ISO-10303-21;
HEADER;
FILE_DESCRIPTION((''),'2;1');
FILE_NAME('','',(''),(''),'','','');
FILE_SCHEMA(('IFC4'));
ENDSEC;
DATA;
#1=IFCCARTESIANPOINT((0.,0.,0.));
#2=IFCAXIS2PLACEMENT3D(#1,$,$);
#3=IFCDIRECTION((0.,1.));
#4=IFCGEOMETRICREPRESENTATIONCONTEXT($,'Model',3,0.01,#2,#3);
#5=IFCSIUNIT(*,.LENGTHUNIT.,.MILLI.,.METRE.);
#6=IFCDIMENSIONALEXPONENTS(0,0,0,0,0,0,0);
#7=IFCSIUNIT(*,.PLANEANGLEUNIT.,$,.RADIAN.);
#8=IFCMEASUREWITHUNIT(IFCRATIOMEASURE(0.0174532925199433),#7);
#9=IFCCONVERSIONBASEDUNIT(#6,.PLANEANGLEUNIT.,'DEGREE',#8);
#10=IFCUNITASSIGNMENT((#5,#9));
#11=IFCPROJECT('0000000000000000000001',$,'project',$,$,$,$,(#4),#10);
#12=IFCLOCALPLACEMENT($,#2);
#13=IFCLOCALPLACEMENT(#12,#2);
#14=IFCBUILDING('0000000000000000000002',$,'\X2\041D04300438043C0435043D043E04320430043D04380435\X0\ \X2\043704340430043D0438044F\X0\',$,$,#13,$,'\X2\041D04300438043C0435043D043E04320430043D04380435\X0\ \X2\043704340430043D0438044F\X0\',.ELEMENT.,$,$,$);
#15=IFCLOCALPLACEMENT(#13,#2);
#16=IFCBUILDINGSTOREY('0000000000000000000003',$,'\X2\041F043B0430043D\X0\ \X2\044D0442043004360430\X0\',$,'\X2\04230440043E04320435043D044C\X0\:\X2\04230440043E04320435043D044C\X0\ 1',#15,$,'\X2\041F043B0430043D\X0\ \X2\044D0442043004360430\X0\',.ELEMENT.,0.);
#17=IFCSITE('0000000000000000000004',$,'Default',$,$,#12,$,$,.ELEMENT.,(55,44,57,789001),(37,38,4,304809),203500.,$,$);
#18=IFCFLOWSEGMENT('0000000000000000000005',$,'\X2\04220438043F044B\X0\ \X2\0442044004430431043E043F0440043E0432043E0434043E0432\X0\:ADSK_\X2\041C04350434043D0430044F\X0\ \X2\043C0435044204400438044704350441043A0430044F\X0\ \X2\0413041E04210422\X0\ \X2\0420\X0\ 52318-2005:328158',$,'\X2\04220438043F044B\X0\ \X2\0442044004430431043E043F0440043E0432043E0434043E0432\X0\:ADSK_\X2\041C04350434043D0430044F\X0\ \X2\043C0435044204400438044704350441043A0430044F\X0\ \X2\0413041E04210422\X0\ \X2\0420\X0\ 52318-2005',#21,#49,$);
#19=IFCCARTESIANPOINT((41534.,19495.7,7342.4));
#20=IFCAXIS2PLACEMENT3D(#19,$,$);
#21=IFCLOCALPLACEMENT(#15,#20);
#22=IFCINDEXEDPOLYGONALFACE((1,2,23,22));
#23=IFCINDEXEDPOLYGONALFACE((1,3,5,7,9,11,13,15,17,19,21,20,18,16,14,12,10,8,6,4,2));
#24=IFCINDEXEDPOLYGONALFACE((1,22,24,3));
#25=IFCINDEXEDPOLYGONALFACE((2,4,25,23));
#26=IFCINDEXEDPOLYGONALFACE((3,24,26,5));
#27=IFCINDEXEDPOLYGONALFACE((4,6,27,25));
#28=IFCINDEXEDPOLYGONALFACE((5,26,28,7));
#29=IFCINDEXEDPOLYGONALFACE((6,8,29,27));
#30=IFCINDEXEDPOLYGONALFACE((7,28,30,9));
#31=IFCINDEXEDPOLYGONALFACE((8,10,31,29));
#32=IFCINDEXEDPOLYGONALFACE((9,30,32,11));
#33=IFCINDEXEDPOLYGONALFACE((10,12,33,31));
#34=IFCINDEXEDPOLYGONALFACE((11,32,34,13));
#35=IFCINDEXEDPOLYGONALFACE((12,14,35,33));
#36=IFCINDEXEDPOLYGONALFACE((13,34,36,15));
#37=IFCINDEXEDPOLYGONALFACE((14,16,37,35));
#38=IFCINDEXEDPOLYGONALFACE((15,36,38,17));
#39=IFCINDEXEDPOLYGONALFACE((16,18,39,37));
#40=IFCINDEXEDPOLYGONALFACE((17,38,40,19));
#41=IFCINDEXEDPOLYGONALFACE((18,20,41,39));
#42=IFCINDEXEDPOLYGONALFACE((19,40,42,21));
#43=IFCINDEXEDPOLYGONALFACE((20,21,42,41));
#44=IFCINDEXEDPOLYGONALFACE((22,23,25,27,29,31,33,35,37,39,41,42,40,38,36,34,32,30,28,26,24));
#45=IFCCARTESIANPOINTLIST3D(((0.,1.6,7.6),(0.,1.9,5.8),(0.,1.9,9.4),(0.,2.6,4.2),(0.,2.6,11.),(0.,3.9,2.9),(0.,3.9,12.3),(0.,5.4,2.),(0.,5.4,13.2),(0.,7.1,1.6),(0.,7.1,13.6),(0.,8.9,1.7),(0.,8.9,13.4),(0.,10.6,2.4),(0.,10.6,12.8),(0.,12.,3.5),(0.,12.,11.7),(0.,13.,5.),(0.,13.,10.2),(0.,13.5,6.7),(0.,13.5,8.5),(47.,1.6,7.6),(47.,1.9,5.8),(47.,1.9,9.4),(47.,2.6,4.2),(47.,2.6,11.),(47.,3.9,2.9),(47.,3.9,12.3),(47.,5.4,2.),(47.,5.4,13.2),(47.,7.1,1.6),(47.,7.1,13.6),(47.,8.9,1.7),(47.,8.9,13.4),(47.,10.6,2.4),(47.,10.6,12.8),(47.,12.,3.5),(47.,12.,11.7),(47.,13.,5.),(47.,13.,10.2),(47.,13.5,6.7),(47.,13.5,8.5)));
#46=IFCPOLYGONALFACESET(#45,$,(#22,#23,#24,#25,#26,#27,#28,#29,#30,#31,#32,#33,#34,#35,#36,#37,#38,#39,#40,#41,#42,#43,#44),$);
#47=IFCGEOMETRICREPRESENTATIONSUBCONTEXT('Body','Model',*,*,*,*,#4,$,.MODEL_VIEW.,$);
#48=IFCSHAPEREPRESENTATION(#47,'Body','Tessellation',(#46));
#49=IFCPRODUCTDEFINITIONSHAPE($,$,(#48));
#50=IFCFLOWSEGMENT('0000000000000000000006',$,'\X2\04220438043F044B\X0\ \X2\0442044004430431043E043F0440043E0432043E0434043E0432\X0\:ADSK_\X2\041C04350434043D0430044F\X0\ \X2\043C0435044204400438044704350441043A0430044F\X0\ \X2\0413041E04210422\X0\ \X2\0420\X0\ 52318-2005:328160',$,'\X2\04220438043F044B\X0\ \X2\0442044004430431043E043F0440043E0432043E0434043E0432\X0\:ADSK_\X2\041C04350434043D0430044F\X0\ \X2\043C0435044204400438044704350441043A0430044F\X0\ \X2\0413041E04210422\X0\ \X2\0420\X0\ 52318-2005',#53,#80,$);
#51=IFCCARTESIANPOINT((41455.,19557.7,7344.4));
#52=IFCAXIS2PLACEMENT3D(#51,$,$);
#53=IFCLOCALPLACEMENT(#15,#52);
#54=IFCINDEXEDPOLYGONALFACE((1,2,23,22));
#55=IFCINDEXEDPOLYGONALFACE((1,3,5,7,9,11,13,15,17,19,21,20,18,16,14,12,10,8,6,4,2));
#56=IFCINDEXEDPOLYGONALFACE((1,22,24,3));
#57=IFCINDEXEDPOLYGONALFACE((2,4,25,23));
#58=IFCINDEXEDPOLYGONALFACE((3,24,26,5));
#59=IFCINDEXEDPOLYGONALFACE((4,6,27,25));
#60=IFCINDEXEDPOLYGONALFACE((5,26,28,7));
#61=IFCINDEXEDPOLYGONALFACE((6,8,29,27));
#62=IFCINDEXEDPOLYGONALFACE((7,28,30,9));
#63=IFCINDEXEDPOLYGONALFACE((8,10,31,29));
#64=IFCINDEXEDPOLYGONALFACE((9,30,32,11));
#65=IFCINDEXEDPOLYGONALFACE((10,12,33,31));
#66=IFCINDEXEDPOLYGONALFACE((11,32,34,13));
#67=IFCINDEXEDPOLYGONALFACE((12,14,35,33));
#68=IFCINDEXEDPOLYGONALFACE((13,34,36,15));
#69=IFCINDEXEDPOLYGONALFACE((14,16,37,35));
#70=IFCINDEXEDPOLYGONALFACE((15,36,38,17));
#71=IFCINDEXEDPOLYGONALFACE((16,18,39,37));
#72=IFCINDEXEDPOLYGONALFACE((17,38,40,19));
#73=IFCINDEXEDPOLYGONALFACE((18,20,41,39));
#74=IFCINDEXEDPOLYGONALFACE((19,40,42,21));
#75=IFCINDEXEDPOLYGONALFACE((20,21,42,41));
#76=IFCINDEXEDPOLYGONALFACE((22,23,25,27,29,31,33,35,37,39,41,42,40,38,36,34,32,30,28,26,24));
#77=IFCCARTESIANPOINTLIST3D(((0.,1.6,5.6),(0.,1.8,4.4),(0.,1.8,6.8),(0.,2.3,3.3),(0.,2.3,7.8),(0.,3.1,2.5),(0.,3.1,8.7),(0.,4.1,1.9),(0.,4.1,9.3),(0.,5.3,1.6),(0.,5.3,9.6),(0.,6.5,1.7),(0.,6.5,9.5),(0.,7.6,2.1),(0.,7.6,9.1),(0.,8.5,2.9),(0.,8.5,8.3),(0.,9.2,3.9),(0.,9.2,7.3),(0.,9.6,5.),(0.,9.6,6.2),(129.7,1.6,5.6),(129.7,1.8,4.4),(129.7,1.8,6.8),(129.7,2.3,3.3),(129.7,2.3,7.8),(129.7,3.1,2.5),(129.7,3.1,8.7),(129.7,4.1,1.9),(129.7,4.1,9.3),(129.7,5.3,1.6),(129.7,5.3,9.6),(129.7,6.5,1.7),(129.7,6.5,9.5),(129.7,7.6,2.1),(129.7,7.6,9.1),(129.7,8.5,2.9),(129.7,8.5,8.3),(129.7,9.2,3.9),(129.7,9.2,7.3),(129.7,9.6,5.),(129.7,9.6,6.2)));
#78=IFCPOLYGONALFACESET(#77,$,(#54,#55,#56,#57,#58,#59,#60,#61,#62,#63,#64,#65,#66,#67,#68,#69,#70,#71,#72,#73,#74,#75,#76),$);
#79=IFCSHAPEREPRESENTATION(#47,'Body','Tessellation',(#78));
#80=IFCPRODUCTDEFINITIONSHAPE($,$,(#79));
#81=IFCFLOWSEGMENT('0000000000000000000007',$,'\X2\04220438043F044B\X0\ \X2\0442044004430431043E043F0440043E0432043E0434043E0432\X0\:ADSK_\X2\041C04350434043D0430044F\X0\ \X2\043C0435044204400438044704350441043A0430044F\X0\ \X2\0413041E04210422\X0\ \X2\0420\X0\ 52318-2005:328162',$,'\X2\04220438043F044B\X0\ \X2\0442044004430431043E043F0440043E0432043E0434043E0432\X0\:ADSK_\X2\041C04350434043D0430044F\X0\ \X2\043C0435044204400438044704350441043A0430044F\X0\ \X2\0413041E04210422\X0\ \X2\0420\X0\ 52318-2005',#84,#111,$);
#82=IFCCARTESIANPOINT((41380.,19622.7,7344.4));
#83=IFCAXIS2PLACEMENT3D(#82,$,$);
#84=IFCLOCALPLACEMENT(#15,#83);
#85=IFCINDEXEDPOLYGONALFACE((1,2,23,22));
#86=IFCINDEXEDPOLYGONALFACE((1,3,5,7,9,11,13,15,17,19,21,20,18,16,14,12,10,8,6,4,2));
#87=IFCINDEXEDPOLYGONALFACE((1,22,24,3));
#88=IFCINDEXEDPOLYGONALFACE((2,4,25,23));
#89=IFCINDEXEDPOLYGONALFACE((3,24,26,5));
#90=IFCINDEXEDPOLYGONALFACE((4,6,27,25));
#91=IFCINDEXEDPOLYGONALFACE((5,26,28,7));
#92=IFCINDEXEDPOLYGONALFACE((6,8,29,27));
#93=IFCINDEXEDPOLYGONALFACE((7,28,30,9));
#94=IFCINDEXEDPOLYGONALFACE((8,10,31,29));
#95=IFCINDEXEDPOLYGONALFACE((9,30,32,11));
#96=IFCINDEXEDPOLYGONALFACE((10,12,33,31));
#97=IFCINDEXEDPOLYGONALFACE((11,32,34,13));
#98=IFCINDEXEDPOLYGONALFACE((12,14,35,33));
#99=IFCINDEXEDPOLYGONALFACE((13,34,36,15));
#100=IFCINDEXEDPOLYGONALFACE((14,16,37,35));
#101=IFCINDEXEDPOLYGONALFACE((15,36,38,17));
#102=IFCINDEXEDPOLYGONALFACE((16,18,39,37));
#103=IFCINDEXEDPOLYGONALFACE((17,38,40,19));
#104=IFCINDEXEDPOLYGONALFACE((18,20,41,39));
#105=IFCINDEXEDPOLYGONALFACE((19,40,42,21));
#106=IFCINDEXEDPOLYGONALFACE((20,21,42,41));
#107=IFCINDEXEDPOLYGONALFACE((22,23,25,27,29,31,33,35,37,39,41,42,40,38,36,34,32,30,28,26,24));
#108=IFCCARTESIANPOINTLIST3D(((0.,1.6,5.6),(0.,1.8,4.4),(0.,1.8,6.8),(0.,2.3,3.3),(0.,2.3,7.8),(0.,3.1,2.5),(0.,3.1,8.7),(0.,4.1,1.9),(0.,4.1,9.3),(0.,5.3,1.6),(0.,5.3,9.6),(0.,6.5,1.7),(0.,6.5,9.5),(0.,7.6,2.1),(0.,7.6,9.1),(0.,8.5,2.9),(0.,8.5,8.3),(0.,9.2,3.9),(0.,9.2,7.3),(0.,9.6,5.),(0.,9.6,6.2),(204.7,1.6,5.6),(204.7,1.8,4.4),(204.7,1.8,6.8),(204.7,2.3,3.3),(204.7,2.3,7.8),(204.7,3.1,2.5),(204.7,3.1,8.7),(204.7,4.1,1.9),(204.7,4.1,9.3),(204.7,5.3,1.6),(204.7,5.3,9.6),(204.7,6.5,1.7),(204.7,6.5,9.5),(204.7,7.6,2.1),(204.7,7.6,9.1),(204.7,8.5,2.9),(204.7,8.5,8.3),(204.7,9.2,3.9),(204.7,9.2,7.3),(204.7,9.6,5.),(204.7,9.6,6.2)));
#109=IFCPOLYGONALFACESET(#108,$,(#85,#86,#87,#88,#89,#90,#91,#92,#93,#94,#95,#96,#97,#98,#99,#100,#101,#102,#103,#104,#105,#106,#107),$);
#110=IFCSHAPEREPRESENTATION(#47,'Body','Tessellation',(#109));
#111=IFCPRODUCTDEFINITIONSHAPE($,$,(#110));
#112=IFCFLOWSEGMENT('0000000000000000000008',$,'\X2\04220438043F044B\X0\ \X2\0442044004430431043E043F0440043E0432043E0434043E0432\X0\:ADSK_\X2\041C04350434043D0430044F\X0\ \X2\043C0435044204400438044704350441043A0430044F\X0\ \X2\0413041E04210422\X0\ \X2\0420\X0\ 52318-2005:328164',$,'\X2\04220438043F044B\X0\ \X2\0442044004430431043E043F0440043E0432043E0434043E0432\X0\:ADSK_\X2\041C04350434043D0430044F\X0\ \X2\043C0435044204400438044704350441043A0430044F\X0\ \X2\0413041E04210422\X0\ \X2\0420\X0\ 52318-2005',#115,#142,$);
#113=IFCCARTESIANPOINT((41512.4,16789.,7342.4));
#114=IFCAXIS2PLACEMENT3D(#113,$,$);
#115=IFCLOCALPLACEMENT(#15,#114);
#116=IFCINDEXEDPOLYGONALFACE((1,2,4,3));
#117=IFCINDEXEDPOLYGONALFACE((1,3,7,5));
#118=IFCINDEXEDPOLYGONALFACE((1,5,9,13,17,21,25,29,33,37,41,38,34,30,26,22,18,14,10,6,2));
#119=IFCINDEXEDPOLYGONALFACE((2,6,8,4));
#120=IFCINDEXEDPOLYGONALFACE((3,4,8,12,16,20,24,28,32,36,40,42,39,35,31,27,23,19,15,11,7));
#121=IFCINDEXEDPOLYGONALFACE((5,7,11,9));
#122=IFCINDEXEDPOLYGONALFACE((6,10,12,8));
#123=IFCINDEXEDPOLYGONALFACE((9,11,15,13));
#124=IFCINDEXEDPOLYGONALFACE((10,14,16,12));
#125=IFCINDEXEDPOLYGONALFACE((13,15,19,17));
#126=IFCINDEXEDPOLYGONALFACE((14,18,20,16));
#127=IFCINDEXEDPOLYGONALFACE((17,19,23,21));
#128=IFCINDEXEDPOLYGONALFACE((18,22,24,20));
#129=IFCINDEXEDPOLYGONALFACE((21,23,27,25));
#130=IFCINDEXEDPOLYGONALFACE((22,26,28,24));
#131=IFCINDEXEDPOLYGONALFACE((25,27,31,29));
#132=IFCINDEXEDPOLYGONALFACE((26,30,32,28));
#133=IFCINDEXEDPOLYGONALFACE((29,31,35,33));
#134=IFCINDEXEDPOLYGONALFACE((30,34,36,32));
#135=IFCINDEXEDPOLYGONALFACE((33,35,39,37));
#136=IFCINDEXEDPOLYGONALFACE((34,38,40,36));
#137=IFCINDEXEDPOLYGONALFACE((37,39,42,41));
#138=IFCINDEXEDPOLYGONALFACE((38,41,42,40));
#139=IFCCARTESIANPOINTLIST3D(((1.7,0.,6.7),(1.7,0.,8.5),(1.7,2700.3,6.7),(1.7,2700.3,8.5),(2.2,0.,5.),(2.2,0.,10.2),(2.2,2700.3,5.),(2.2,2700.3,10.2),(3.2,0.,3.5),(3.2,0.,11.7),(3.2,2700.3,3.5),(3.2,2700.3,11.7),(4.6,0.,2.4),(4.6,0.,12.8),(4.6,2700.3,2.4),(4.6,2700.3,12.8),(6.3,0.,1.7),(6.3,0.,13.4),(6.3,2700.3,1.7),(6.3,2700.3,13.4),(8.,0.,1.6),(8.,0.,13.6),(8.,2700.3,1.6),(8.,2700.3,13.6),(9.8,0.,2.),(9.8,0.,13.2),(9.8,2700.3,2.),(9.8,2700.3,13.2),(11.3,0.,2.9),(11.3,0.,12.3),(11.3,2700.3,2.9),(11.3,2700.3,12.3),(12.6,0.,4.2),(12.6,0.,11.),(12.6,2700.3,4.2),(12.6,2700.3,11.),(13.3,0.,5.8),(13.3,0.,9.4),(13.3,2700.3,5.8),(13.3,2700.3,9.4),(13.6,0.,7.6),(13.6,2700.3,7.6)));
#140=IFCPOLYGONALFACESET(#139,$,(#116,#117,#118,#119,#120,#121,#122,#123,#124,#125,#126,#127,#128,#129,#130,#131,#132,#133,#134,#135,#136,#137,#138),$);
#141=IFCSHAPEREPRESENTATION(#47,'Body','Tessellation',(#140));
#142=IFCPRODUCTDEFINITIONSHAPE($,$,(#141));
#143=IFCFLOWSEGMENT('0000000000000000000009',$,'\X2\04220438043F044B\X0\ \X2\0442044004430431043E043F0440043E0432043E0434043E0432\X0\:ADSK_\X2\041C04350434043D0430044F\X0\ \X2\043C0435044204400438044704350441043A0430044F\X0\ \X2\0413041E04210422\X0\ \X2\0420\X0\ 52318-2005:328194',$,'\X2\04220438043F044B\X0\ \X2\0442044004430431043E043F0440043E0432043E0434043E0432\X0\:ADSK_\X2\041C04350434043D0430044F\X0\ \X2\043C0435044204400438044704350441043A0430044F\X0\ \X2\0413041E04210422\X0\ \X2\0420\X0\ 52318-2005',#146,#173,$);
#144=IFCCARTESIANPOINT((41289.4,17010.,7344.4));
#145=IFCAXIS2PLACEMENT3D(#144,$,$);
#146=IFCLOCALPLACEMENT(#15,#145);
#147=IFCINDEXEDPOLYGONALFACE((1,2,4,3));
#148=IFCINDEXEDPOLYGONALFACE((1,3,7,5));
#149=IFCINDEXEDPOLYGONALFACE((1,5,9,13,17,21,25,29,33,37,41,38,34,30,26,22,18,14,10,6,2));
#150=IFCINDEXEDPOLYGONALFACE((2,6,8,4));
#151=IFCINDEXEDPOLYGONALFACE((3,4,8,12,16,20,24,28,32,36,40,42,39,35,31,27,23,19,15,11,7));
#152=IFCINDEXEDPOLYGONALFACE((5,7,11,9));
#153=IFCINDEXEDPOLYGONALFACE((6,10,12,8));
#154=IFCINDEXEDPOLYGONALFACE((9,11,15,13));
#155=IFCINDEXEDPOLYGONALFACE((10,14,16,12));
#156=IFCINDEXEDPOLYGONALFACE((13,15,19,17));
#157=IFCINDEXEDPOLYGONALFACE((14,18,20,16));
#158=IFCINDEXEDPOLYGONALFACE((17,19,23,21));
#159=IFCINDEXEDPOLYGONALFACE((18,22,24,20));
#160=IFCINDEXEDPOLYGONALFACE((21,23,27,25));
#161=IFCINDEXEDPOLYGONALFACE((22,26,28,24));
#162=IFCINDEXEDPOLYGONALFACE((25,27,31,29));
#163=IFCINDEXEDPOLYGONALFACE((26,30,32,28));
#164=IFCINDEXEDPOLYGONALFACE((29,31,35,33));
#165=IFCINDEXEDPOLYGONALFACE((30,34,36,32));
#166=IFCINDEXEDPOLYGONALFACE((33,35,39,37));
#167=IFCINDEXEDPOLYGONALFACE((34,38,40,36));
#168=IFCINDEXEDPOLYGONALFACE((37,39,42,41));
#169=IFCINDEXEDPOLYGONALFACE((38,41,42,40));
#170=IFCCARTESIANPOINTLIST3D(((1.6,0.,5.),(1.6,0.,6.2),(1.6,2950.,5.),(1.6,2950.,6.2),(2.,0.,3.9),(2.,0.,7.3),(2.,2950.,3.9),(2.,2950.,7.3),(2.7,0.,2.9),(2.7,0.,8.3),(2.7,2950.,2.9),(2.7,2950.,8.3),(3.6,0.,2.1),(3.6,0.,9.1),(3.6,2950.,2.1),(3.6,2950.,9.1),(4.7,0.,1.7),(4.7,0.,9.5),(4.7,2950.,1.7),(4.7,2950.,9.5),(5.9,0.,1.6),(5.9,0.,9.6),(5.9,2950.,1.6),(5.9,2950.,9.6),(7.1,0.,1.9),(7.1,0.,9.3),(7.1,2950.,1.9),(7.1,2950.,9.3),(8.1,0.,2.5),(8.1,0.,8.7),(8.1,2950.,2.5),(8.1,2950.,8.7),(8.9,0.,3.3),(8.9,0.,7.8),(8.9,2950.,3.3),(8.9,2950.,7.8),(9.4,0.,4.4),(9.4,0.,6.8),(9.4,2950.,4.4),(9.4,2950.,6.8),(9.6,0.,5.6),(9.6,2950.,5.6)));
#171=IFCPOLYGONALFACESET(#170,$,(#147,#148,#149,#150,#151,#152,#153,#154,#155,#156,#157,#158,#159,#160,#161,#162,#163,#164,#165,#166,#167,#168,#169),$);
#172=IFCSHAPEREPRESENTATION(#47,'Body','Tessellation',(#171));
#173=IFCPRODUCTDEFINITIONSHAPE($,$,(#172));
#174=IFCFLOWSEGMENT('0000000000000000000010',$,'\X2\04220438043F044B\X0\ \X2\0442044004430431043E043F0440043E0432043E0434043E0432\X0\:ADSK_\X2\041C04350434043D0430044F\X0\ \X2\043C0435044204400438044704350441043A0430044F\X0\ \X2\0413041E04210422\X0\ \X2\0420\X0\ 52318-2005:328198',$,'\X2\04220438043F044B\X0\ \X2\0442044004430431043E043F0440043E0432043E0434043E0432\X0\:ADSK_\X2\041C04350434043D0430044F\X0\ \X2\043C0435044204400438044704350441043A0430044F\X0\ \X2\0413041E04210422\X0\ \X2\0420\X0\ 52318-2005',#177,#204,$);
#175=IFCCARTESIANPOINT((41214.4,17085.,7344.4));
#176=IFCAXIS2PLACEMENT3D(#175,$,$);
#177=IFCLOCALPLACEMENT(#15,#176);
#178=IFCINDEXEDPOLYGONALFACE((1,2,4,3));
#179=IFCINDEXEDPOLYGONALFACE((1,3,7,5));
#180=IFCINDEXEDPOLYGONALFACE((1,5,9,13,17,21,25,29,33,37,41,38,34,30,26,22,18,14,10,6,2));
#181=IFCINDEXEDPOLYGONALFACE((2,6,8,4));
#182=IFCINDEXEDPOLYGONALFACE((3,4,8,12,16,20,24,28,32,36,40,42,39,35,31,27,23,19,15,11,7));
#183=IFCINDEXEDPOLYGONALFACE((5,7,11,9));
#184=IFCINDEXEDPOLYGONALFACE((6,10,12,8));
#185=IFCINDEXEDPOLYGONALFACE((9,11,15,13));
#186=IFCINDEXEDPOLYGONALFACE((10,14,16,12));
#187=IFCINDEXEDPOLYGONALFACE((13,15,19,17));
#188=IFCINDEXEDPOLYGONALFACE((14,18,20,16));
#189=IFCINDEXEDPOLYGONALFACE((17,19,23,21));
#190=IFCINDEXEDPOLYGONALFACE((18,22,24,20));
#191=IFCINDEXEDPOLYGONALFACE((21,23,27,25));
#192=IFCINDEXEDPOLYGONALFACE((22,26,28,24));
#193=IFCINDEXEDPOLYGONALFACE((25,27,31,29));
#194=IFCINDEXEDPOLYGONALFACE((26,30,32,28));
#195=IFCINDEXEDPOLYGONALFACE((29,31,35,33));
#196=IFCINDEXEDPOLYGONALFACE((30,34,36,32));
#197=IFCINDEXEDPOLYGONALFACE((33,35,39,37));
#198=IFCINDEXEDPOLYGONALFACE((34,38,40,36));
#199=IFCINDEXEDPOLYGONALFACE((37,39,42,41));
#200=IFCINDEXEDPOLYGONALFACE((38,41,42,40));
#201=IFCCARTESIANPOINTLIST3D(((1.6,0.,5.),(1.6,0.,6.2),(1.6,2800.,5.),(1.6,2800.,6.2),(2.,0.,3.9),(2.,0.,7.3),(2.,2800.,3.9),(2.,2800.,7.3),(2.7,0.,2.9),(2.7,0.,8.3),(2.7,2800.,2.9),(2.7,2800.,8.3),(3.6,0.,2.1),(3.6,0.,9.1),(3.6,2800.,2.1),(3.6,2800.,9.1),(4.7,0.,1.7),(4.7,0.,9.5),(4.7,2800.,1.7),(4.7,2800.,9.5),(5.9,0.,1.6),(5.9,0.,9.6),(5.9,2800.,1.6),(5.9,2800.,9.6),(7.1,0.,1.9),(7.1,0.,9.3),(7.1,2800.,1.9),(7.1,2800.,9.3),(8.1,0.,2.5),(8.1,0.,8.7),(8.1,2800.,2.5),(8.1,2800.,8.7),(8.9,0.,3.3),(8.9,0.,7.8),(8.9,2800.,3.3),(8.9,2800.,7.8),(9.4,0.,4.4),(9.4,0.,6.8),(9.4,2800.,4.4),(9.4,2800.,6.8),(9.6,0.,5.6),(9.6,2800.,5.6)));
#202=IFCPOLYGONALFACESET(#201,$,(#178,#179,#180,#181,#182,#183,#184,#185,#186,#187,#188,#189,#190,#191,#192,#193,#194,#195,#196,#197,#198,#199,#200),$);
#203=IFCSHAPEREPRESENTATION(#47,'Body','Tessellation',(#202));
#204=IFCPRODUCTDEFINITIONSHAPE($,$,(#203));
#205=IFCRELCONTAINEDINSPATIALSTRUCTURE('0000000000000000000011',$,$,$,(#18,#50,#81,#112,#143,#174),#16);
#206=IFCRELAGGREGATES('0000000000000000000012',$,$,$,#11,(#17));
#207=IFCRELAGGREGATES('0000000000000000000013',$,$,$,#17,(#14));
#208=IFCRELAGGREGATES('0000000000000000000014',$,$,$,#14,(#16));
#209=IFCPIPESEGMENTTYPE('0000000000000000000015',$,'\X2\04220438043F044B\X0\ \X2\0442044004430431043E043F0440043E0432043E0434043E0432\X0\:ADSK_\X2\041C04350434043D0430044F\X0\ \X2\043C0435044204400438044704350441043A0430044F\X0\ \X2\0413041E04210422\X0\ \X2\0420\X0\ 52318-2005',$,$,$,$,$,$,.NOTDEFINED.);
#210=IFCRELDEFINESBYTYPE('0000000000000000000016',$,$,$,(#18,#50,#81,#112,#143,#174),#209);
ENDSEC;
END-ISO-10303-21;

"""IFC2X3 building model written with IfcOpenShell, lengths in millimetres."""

from ifc_helpers import new_model, entity, si_unit, converted_unit, direction, frame, origin, origin_2d_with_axis, place, context, subcontext, project, spatial, circle, extrude, type_object, element, save


model = new_model("IFC2X3")

# Units and contexts
model_context = context("Model", 3, precision=0.01, world=origin(), true_north=direction((0.0, 1.0)))
body_context = subcontext(model_context, "Body", "Model", "MODEL_VIEW")
ifc_project = project(units=[si_unit("LENGTHUNIT", "METRE", prefix="MILLI"), converted_unit("PLANEANGLEUNIT", "DEGREE", entity("IfcRatioMeasure", 0.0174532925199433), si_unit("PLANEANGLEUNIT", "RADIAN"), dimensions=[0, 0, 0, 0, 0, 0, 0])], contexts=[model_context])

# Site, building, storey
site_placement = place(None, frame((0.0, 0.0, 0.0)))
site = spatial("IfcSite", under=ifc_project, at=site_placement, Name="Default", CompositionType="ELEMENT", RefLatitude=(55, 44, 57, 789001), RefLongitude=(37, 38, 4, 304809), RefElevation=203500.0)
building_placement = place(site_placement, origin())
building = spatial("IfcBuilding", under=site, at=building_placement, Name="Наименование здания", LongName="Наименование здания", CompositionType="ELEMENT")
storey_placement = place(building_placement, origin())
storey = spatial("IfcBuildingStorey", under=building, at=storey_placement, Name="План этажа", ObjectType="Уровень:Уровень 1", LongName="План этажа", CompositionType="ELEMENT", Elevation=0.0)

# Flow segments
pipe_segment_type = type_object("IfcPipeSegmentType", Name="Типы трубопроводов:ADSK_Медная метрическая ГОСТ Р 52318-2005", PredefinedType="NOTDEFINED")
flow_segment_1_placement = place(storey_placement, frame((41534.0, 19495.7, 7342.4)))
element("IfcFlowSegment", 1, at=flow_segment_1_placement, inside=storey, type_object=pipe_segment_type, Name="Типы трубопроводов:ADSK_Медная метрическая ГОСТ Р 52318-2005:328158", ObjectType="Типы трубопроводов:ADSK_Медная метрическая ГОСТ Р 52318-2005", context=body_context, shape_type="SweptSolid", body=[
    extrude(circle(Radius=6.0, at=origin_2d_with_axis()), frame((0.0, 7.6, 7.6), z_axis=(1.0, 0.0, 0.0), x_axis=(0.0, -1.0, 0.0)), (0.0, 0.0, 1.0), 47.0),
])
flow_segment_2_placement = place(storey_placement, frame((41455.0, 19557.7, 7344.4)))
element("IfcFlowSegment", 2, at=flow_segment_2_placement, inside=storey, type_object=pipe_segment_type, Name="Типы трубопроводов:ADSK_Медная метрическая ГОСТ Р 52318-2005:328160", ObjectType="Типы трубопроводов:ADSK_Медная метрическая ГОСТ Р 52318-2005", context=body_context, shape_type="SweptSolid", body=[
    extrude(circle(Radius=4.0, at=origin_2d_with_axis()), frame((0.0, 5.6, 5.6), z_axis=(1.0, 0.0, 0.0), x_axis=(0.0, -1.0, 0.0)), (0.0, 0.0, 1.0), 129.7),
])
flow_segment_3_placement = place(storey_placement, frame((41380.0, 19622.7, 7344.4)))
element("IfcFlowSegment", 3, at=flow_segment_3_placement, inside=storey, type_object=pipe_segment_type, Name="Типы трубопроводов:ADSK_Медная метрическая ГОСТ Р 52318-2005:328162", ObjectType="Типы трубопроводов:ADSK_Медная метрическая ГОСТ Р 52318-2005", context=body_context, shape_type="SweptSolid", body=[
    extrude(circle(Radius=4.0, at=origin_2d_with_axis()), frame((0.0, 5.6, 5.6), z_axis=(1.0, 0.0, 0.0), x_axis=(0.0, -1.0, 0.0)), (0.0, 0.0, 1.0), 204.7),
])
flow_segment_4_placement = place(storey_placement, frame((41512.4, 16789.0, 7342.4)))
element("IfcFlowSegment", 4, at=flow_segment_4_placement, inside=storey, type_object=pipe_segment_type, Name="Типы трубопроводов:ADSK_Медная метрическая ГОСТ Р 52318-2005:328164", ObjectType="Типы трубопроводов:ADSK_Медная метрическая ГОСТ Р 52318-2005", context=body_context, shape_type="SweptSolid", body=[
    extrude(circle(Radius=6.0, at=origin_2d_with_axis()), frame((7.6, 0.0, 7.6), z_axis=(0.0, 1.0, 0.0), x_axis=(1.0, 0.0, 0.0)), (0.0, 0.0, 1.0), 2700.3),
])
flow_segment_5_placement = place(storey_placement, frame((41289.4, 17010.0, 7344.4)))
element("IfcFlowSegment", 5, at=flow_segment_5_placement, inside=storey, type_object=pipe_segment_type, Name="Типы трубопроводов:ADSK_Медная метрическая ГОСТ Р 52318-2005:328194", ObjectType="Типы трубопроводов:ADSK_Медная метрическая ГОСТ Р 52318-2005", context=body_context, shape_type="SweptSolid", body=[
    extrude(circle(Radius=4.0, at=origin_2d_with_axis()), frame((5.6, 0.0, 5.6), z_axis=(0.0, 1.0, 0.0), x_axis=(1.0, 0.0, 0.0)), (0.0, 0.0, 1.0), 2950.0),
])
flow_segment_6_placement = place(storey_placement, frame((41214.4, 17085.0, 7344.4)))
element("IfcFlowSegment", 6, at=flow_segment_6_placement, inside=storey, type_object=pipe_segment_type, Name="Типы трубопроводов:ADSK_Медная метрическая ГОСТ Р 52318-2005:328198", ObjectType="Типы трубопроводов:ADSK_Медная метрическая ГОСТ Р 52318-2005", context=body_context, shape_type="SweptSolid", body=[
    extrude(circle(Radius=4.0, at=origin_2d_with_axis()), frame((5.6, 0.0, 5.6), z_axis=(0.0, 1.0, 0.0), x_axis=(1.0, 0.0, 0.0)), (0.0, 0.0, 1.0), 2800.0),
])

save(model, "model.ifc")
